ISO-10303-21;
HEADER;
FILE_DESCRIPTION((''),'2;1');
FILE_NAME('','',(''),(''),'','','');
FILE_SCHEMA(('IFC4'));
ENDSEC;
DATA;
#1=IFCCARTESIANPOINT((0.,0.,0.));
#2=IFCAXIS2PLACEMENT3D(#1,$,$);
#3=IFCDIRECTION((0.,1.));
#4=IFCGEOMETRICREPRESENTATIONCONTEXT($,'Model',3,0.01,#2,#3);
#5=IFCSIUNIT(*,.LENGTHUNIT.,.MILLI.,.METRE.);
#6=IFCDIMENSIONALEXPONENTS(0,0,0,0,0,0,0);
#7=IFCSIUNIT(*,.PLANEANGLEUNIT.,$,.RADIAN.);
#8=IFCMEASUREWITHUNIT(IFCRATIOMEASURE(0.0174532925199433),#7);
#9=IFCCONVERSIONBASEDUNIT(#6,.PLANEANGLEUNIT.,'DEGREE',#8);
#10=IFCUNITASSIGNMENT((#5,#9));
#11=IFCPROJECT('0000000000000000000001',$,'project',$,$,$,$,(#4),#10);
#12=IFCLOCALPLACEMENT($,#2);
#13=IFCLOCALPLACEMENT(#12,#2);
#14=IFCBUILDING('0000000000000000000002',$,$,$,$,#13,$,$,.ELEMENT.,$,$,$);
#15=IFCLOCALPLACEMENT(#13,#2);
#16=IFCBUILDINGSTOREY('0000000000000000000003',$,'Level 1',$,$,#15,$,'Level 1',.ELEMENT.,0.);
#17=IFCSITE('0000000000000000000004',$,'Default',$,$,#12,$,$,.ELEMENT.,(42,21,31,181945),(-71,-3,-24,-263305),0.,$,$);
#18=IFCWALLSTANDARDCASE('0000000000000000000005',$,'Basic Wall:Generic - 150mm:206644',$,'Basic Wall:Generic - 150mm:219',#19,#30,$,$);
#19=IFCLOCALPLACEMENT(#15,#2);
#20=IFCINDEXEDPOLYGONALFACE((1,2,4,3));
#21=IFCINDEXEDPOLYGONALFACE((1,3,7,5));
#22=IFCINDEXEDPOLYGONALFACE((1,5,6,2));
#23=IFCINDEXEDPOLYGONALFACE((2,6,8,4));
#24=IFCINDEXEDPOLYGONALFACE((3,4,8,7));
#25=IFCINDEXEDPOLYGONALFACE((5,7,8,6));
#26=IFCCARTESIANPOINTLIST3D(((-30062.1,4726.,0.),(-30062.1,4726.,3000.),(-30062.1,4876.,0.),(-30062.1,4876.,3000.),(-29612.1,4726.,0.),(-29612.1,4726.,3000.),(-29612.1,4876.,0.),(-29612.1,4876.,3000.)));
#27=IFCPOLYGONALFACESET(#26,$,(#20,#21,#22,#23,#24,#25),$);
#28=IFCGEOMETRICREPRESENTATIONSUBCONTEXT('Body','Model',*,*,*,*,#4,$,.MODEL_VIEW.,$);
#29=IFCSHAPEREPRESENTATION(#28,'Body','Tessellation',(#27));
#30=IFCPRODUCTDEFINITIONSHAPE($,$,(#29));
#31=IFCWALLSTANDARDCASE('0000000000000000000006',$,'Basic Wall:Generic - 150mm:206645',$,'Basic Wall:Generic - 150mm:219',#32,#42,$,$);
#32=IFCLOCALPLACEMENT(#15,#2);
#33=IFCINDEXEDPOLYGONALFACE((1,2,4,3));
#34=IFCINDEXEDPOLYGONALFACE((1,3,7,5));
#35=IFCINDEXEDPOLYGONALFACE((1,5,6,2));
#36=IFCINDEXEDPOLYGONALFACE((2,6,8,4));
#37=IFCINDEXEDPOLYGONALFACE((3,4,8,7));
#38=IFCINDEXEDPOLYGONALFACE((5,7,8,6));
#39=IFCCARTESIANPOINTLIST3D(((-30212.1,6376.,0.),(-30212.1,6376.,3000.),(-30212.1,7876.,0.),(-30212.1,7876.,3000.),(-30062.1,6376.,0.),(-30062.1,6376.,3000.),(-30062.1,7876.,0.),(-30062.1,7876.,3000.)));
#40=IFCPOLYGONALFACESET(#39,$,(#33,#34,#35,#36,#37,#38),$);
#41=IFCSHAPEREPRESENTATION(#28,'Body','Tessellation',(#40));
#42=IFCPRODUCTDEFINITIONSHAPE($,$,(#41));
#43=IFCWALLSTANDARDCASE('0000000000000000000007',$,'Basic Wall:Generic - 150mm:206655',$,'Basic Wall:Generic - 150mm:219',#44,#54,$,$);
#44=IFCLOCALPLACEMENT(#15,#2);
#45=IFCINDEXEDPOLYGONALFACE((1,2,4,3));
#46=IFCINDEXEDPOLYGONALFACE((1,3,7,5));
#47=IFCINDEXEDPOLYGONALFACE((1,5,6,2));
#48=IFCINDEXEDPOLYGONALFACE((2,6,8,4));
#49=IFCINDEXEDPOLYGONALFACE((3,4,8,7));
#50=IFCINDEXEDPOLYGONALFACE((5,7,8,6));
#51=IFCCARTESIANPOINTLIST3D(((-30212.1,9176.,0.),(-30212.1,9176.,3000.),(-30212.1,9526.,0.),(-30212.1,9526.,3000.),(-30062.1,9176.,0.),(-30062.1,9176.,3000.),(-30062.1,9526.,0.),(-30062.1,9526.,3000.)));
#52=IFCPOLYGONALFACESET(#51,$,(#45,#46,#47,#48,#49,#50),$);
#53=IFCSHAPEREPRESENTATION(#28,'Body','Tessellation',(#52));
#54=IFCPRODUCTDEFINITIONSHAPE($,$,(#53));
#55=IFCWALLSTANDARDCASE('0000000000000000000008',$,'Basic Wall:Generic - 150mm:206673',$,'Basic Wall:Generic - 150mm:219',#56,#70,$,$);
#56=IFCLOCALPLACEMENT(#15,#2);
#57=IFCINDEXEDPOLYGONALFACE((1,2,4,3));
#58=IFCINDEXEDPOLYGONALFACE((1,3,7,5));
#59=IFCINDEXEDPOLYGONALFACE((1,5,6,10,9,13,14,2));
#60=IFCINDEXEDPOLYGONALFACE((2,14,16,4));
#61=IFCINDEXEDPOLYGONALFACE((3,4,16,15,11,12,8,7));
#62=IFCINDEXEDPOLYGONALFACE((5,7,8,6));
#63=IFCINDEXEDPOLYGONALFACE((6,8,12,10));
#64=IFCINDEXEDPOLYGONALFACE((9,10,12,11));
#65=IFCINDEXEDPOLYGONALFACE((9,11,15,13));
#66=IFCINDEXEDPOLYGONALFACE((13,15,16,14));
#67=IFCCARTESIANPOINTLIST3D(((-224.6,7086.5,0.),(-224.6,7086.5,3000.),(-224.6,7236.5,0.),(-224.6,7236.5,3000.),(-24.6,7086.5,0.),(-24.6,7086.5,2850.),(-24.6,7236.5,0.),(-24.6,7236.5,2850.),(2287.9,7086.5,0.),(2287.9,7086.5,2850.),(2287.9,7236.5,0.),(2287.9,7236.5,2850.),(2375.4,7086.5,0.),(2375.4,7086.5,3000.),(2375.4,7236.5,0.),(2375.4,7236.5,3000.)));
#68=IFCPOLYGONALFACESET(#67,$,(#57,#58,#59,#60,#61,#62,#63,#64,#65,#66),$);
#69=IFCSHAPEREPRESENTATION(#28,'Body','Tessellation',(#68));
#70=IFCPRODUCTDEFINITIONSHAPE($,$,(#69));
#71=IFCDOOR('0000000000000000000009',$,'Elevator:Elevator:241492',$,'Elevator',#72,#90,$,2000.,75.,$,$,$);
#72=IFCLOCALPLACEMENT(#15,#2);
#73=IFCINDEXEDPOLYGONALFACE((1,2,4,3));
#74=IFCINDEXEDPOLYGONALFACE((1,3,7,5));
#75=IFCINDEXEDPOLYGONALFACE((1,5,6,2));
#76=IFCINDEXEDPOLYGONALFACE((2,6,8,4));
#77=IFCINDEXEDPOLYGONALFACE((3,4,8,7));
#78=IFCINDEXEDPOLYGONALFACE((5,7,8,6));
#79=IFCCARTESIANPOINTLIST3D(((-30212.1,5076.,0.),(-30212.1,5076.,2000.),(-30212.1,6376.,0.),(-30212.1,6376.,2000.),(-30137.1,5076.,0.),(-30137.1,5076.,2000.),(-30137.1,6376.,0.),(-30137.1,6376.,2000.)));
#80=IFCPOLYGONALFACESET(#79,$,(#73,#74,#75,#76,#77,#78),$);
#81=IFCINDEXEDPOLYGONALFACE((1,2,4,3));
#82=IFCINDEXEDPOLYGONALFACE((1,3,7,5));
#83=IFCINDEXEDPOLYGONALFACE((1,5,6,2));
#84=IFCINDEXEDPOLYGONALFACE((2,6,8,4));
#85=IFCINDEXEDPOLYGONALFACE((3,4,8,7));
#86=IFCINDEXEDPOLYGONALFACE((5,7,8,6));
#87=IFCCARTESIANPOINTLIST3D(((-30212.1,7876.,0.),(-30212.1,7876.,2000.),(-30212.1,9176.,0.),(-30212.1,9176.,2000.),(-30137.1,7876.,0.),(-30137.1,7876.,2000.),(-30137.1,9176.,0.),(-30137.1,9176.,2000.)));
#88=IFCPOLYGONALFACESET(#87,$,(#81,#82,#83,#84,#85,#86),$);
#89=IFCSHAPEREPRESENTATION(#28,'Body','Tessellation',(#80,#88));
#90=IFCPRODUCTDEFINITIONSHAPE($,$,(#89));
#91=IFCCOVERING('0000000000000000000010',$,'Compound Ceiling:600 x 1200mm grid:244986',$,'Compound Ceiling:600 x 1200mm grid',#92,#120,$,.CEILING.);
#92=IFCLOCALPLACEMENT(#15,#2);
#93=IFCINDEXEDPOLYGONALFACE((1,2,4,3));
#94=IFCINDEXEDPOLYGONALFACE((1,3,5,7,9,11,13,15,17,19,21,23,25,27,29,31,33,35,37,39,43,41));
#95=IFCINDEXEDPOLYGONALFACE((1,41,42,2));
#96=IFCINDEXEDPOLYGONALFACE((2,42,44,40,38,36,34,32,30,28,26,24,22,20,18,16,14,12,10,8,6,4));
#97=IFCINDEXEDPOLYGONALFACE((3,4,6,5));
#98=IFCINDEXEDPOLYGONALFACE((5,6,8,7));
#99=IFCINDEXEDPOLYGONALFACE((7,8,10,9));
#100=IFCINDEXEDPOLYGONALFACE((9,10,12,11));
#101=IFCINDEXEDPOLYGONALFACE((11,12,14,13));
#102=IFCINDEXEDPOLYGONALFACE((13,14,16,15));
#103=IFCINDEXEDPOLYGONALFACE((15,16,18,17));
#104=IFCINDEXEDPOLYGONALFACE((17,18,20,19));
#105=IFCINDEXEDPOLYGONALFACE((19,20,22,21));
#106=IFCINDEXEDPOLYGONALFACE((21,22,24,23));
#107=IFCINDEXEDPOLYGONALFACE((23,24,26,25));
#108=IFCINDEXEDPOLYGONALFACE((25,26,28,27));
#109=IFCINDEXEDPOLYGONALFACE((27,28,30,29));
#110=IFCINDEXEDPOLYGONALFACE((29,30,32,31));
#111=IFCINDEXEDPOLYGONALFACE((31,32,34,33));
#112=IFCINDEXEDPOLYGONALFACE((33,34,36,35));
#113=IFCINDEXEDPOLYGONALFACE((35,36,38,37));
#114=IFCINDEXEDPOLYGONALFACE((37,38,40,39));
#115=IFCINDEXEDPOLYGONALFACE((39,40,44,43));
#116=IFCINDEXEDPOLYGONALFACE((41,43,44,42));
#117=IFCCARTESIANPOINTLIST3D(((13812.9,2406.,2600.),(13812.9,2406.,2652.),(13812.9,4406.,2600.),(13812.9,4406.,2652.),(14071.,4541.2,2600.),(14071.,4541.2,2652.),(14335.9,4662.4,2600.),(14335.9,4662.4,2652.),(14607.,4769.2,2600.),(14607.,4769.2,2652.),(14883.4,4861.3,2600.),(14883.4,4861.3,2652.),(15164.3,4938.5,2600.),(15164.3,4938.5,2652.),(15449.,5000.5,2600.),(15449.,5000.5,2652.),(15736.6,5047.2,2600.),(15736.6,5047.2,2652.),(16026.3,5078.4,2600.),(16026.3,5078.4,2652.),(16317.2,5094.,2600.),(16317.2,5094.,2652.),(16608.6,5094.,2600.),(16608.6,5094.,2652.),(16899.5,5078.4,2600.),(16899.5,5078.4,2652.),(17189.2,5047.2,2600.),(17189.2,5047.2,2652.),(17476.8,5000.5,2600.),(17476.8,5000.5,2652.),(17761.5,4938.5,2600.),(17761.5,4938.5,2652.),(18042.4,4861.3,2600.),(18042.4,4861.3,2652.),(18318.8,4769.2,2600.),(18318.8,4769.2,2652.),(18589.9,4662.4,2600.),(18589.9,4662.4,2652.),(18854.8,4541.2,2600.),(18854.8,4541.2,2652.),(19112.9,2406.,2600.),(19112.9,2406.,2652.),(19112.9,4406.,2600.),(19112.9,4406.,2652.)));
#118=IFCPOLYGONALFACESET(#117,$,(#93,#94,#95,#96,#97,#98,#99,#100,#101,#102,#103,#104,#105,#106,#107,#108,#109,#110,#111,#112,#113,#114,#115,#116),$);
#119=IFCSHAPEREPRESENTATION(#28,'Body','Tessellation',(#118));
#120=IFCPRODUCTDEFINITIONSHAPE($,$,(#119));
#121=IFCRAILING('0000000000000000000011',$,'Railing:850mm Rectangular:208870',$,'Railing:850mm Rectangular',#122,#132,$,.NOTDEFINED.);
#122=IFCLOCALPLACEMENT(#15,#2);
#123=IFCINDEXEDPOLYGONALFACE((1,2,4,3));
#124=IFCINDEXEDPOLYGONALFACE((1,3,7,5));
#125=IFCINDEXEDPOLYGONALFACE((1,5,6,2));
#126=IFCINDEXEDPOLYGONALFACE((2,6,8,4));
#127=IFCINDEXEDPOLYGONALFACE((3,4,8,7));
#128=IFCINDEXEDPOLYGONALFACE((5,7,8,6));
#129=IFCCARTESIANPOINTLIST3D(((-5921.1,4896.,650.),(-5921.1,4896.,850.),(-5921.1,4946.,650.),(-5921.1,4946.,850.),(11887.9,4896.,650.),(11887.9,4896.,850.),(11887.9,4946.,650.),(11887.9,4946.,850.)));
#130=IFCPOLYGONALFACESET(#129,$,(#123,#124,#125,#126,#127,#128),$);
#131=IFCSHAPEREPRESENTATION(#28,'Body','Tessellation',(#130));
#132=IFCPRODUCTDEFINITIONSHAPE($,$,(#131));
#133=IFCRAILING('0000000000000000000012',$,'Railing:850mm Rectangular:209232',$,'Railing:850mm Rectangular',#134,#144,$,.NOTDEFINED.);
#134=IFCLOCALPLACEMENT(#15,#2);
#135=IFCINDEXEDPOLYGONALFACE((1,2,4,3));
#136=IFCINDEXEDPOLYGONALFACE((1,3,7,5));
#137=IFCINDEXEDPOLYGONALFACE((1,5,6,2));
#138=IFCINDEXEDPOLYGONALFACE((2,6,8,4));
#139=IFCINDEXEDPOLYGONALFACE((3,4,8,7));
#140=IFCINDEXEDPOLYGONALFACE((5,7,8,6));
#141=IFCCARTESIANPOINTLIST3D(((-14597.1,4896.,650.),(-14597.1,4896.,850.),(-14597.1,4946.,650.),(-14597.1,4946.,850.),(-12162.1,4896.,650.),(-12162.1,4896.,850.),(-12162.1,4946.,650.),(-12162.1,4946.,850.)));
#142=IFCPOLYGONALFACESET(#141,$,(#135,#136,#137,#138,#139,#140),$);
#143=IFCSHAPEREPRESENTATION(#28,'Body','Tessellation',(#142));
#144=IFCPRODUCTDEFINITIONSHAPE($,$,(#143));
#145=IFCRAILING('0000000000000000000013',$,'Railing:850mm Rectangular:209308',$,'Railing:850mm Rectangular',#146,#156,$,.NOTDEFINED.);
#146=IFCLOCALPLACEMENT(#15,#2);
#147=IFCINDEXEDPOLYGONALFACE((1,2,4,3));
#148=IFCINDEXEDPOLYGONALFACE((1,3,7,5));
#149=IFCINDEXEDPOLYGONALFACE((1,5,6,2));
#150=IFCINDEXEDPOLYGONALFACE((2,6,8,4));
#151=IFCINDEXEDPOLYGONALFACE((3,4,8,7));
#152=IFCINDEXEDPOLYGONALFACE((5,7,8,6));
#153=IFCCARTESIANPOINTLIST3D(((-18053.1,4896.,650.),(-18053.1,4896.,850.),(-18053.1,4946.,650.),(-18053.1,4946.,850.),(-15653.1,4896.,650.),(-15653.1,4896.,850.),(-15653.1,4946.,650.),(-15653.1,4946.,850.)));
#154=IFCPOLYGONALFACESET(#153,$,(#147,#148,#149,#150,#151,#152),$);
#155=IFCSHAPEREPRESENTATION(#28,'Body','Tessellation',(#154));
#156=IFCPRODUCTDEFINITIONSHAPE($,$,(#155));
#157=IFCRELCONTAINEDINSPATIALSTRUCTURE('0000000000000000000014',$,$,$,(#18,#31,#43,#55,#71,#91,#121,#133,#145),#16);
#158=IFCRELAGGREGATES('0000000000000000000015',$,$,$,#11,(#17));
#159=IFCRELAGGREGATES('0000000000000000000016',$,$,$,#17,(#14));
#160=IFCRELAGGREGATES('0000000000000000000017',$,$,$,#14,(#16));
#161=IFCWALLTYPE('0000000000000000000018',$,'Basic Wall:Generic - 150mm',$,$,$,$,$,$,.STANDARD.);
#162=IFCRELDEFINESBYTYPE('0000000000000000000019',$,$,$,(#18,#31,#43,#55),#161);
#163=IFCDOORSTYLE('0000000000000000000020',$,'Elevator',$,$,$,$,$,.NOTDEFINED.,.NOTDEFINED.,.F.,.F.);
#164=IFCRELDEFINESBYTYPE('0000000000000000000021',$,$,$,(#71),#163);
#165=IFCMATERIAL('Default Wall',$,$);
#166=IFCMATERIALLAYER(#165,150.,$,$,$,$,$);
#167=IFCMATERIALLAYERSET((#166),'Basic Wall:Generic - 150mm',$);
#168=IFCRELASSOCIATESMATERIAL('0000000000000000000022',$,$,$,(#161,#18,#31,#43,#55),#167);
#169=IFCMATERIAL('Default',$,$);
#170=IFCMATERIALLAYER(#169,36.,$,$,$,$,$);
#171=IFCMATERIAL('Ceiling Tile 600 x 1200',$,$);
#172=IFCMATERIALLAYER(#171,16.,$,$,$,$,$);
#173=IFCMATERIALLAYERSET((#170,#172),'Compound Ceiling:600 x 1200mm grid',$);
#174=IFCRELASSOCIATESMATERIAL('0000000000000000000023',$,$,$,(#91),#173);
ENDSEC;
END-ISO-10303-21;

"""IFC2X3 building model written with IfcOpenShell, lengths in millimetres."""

from ifc_helpers import new_model, entity, si_unit, converted_unit, direction, frame, frame_2d, origin, origin_2d_with_axis, place, context, subcontext, project, spatial, polyline, circle_curve, parameter, trimmed, segment, composite_curve, rectangle, outline, extrude, source, transform, mapped, material, layer, layer_set, layer_usage, type_object, type_shapes, element, save


model = new_model("IFC2X3")

# Units and contexts
model_context = context("Model", 3, precision=0.01, world=origin(), true_north=direction((0.0, 1.0)))
body_context = subcontext(model_context, "Body", "Model", "MODEL_VIEW")
ifc_project = project(units=[si_unit("LENGTHUNIT", "METRE", prefix="MILLI"), converted_unit("PLANEANGLEUNIT", "DEGREE", entity("IfcRatioMeasure", 0.0174532925199433), si_unit("PLANEANGLEUNIT", "RADIAN"), dimensions=[0, 0, 0, 0, 0, 0, 0])], contexts=[model_context])

# Site, building, storey
site_placement = place(None, origin())
site = spatial("IfcSite", under=ifc_project, at=site_placement, Name="Default", CompositionType="ELEMENT", RefLatitude=(42, 21, 31, 181945), RefLongitude=(-71, -3, -24, -263305), RefElevation=0.0)
building_placement = place(site_placement, origin())
building = spatial("IfcBuilding", under=site, at=building_placement, CompositionType="ELEMENT")
storey_placement = place(building_placement, origin())
storey = spatial("IfcBuildingStorey", under=building, at=storey_placement, Name="Level 1", LongName="Level 1", CompositionType="ELEMENT", Elevation=0.0)

# Shared definitions
ifc_material_1 = material(Name="Default Wall")

# Shared definitions
ifc_layer_1 = layer(ifc_material_1, 150.0)
ifc_layer_set_1 = layer_set([ifc_layer_1], Name="Basic Wall:Generic - 150mm")
wall_type = type_object("IfcWallType", Name="Basic Wall:Generic - 150mm", PredefinedType="STANDARD", material=ifc_layer_set_1)

# Walls
ifc_layer_usage_1 = layer_usage(ifc_layer_set_1, "AXIS2", "NEGATIVE", 75.0)
wall_1_placement = place(storey_placement, frame((-30062.1, 4801.0, 0.0)))
element("IfcWallStandardCase", 1, at=wall_1_placement, inside=storey, type_object=wall_type, material=ifc_layer_usage_1, Name="Basic Wall:Generic - 150mm:206644", ObjectType="Basic Wall:Generic - 150mm:219", context=body_context, shape_type="SweptSolid", body=[
    extrude(rectangle(XDim=450.0, YDim=150.0, at=frame_2d((225.0, 0.0), x_axis=(-1.0, 0.0))), origin(), (0.0, 0.0, 1.0), 3000.0),
])
ifc_layer_usage_2 = layer_usage(ifc_layer_set_1, "AXIS2", "NEGATIVE", 75.0)
wall_2_placement = place(storey_placement, frame((-30137.1, 7876.0, 0.0), z_axis=(0.0, 0.0, 1.0), x_axis=(0.0, -1.0, 0.0)))
element("IfcWallStandardCase", 2, at=wall_2_placement, inside=storey, type_object=wall_type, material=ifc_layer_usage_2, Name="Basic Wall:Generic - 150mm:206645", ObjectType="Basic Wall:Generic - 150mm:219", context=body_context, shape_type="SweptSolid", body=[
    extrude(rectangle(XDim=1500.0, YDim=150.0, at=frame_2d((750.0, 0.0), x_axis=(-1.0, 0.0))), origin(), (0.0, 0.0, 1.0), 3000.0),
])
ifc_layer_usage_3 = layer_usage(ifc_layer_set_1, "AXIS2", "NEGATIVE", 75.0)
wall_3_placement = place(storey_placement, frame((-30137.1, 9176.0, 0.0), z_axis=(0.0, 0.0, 1.0), x_axis=(0.0, 1.0, 0.0)))
element("IfcWallStandardCase", 3, at=wall_3_placement, inside=storey, type_object=wall_type, material=ifc_layer_usage_3, Name="Basic Wall:Generic - 150mm:206655", ObjectType="Basic Wall:Generic - 150mm:219", context=body_context, shape_type="SweptSolid", body=[
    extrude(rectangle(XDim=350.0, YDim=150.0, at=frame_2d((175.0, 0.0), x_axis=(-1.0, 0.0))), origin(), (0.0, 0.0, 1.0), 3000.0),
])

# Wall, opening
ifc_layer_usage_4 = layer_usage(ifc_layer_set_1, "AXIS2", "NEGATIVE", 75.0)
wall_4_placement = place(storey_placement, frame((-224.6, 7161.5, 0.0)))
wall_4 = element("IfcWallStandardCase", 4, at=wall_4_placement, inside=storey, type_object=wall_type, material=ifc_layer_usage_4, Name="Basic Wall:Generic - 150mm:206673", ObjectType="Basic Wall:Generic - 150mm:219", context=body_context, shape_type="SweptSolid", body=[
    extrude(rectangle(XDim=2600.0, YDim=150.0, at=frame_2d((1300.0, 0.0), x_axis=(-1.0, 0.0))), origin(), (0.0, 0.0, 1.0), 3000.0),
])
opening_1_placement = place(wall_4_placement, origin())
element("IfcOpeningElement", 5, at=opening_1_placement, cuts=wall_4, ObjectType="Opening", context=body_context, shape_type="SweptSolid", body=[
    extrude(rectangle(XDim=2850.0, YDim=2312.5, at=frame_2d((0.0, 0.0), x_axis=(0.0, 1.0))), frame((1356.2, 75.0, 1425.0), z_axis=(0.0, -1.0, 0.0), x_axis=(1.0, 0.0, 0.0)), (0.0, 0.0, 1.0), 150.0),
])

# Door
door_style = type_object("IfcDoorStyle", Name="Elevator", ConstructionType="NOTDEFINED", OperationType="NOTDEFINED", ParameterTakesPrecedence=False, Sizeable=False)
shared_shape_1 = source(origin(), body_context, "Body", "SweptSolid", [
    extrude(rectangle(XDim=75.0, YDim=1300.0, at=frame_2d((0.0, 0.0), x_axis=(1.0, 0.0))), frame((-30174.6, 5726.0, 0.0)), (0.0, 0.0, 1.0), 2000.0),
    extrude(rectangle(XDim=75.0, YDim=1300.0, at=frame_2d((0.0, 0.0), x_axis=(1.0, 0.0))), frame((-30174.6, 8526.0, 0.0)), (0.0, 0.0, 1.0), 2000.0),
])
type_shapes(door_style, [shared_shape_1])
door_placement = place(storey_placement, origin())
element("IfcDoor", 6, at=door_placement, inside=storey, type_object=door_style, Name="Elevator:Elevator:241492", ObjectType="Elevator", OverallHeight=2000.0, OverallWidth=75.0, context=body_context, shape_type="MappedRepresentation", body=[
    mapped(shared_shape_1, transform((0.0, 0.0, 0.0), scale=1.0)),
])

# Covering
ifc_material_2 = material(Name="Default")
ifc_layer_2 = layer(ifc_material_2, 36.0)
ifc_material_3 = material(Name="Ceiling Tile 600 x 1200")
ifc_layer_3 = layer(ifc_material_3, 16.0)
ifc_layer_set_2 = layer_set([ifc_layer_2, ifc_layer_3], Name="Compound Ceiling:600 x 1200mm grid")
ifc_layer_usage_5 = layer_usage(ifc_layer_set_2, "AXIS3", "NEGATIVE", 0.0)
covering_1_placement = place(storey_placement, origin())
element("IfcCovering", 7, at=covering_1_placement, inside=storey, material=ifc_layer_usage_5, Name="Compound Ceiling:600 x 1200mm grid:244986", ObjectType="Compound Ceiling:600 x 1200mm grid", PredefinedType="CEILING", context=body_context, shape_type="SweptSolid", body=[
    extrude(outline(composite_curve([segment(polyline([(-2650.0, -1000.0), (2650.0, -1000.0)]), True, "CONTINUOUS"), segment(polyline([(2650.0, -1000.0), (2650.0, 1000.0)]), True, "CONTINUOUS"), segment(trimmed(circle_curve(frame_2d((0.0, -3743.8), x_axis=(1.0, 0.0)), 5433.8), [parameter(60.811067)], [parameter(119.188933)], True, "PARAMETER"), True, "CONTINUOUS"), segment(polyline([(-2650.0, 1000.0), (-2650.0, -1000.0)]), True, "CONTINUOUS")], self_intersect=False)), frame((16462.9, 3406.0, 2600.0)), (0.0, 0.0, 1.0), 52.0),
])

# Railings
railing_1_placement = place(storey_placement, origin())
element("IfcRailing", 8, at=railing_1_placement, inside=storey, Name="Railing:850mm Rectangular:208870", ObjectType="Railing:850mm Rectangular", PredefinedType="NOTDEFINED", context=body_context, shape_type="SweptSolid", body=[
    extrude(rectangle(XDim=17809.0, YDim=50.0, at=origin_2d_with_axis()), frame((2983.4, 4921.0, 650.0), z_axis=(0.0, 0.0, 1.0), x_axis=(-1.0, 0.0, 0.0)), (0.0, 0.0, 1.0), 200.0),
])
railing_2_placement = place(storey_placement, origin())
element("IfcRailing", 9, at=railing_2_placement, inside=storey, Name="Railing:850mm Rectangular:209232", ObjectType="Railing:850mm Rectangular", PredefinedType="NOTDEFINED", context=body_context, shape_type="SweptSolid", body=[
    extrude(rectangle(XDim=2435.0, YDim=50.0, at=frame_2d((0.0, 0.0), x_axis=(1.0, 0.0))), frame((-13379.6, 4921.0, 650.0), z_axis=(0.0, 0.0, 1.0), x_axis=(-1.0, 0.0, 0.0)), (0.0, 0.0, 1.0), 200.0),
])
railing_3_placement = place(storey_placement, origin())
element("IfcRailing", 10, at=railing_3_placement, inside=storey, Name="Railing:850mm Rectangular:209308", ObjectType="Railing:850mm Rectangular", PredefinedType="NOTDEFINED", context=body_context, shape_type="SweptSolid", body=[
    extrude(rectangle(XDim=2400.0, YDim=50.0, at=origin_2d_with_axis()), frame((-16853.1, 4921.0, 650.0), z_axis=(0.0, 0.0, 1.0), x_axis=(-1.0, 0.0, 0.0)), (0.0, 0.0, 1.0), 200.0),
])

save(model, "model.ifc")
